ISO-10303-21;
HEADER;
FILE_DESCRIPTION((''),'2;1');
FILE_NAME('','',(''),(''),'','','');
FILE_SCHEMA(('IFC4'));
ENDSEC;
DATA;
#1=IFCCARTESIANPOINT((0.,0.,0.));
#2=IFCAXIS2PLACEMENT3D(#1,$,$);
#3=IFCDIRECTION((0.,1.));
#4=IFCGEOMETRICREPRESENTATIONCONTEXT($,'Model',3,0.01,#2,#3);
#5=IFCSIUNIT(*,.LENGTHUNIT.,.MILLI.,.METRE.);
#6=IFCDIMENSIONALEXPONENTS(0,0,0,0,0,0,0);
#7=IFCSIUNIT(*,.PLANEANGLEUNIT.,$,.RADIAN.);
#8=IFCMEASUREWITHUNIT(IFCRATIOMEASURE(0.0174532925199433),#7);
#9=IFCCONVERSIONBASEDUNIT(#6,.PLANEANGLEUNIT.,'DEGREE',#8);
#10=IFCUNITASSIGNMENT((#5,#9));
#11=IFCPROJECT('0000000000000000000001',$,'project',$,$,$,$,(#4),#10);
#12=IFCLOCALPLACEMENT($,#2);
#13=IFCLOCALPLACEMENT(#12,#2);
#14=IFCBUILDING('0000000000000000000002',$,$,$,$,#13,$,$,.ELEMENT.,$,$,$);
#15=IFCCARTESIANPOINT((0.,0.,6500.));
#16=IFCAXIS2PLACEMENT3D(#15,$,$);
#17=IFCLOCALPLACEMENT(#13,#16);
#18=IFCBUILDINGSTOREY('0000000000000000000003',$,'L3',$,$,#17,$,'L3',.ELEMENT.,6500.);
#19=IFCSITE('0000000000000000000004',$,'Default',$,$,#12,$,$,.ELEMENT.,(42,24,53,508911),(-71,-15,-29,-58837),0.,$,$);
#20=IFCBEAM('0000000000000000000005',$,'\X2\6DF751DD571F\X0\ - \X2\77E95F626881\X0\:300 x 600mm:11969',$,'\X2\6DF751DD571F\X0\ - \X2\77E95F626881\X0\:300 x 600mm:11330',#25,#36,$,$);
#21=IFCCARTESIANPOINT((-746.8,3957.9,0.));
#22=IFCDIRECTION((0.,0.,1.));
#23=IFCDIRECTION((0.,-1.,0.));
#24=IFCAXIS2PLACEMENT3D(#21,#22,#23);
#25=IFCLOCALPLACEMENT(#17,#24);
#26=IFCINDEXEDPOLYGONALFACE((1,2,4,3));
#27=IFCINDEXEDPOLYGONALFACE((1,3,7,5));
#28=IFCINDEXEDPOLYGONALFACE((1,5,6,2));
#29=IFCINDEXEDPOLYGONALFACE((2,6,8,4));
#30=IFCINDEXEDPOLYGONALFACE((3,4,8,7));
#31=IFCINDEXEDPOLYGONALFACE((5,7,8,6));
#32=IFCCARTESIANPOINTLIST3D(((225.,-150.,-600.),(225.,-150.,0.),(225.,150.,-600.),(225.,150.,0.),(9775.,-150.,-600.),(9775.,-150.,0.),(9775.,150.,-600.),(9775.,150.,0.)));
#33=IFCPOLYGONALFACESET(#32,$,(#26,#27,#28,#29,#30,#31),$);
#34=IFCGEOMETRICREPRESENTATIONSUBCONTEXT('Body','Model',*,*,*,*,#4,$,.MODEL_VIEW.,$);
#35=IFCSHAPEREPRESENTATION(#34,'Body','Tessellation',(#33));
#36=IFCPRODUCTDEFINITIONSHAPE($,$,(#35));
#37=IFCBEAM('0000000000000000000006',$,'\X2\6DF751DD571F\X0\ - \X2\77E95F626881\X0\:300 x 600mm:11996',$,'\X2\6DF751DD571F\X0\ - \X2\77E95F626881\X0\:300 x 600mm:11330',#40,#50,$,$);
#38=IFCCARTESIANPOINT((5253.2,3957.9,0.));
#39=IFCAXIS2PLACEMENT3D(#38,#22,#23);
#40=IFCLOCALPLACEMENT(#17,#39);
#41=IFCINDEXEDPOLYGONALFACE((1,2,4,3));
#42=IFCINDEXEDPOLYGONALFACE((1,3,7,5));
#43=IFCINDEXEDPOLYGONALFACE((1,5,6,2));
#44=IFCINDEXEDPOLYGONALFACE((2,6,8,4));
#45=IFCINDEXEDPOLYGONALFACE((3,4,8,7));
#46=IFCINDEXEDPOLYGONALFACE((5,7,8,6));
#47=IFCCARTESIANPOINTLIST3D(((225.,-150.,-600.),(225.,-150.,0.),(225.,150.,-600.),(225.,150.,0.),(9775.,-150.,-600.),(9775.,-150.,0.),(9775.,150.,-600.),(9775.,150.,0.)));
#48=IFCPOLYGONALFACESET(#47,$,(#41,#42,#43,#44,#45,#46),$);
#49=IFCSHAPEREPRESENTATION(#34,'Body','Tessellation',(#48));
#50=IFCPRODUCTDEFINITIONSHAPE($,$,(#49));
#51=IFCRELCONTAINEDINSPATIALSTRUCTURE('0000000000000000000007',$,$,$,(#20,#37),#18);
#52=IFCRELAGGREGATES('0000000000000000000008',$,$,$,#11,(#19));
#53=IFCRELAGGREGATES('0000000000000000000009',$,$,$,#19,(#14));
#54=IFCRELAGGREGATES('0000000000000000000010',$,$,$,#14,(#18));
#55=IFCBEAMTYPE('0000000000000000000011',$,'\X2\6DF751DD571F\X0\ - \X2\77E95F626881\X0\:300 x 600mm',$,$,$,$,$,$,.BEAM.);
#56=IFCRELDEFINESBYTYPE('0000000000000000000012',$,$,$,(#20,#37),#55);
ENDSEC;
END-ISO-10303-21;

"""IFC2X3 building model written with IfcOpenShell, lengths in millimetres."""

from ifc_helpers import new_model, entity, si_unit, converted_unit, direction, frame, frame_2d, origin, origin_2d_with_axis, place, context, subcontext, project, spatial, rectangle, extrude, type_object, element, save


model = new_model("IFC2X3")

# Units and contexts
model_context = context("Model", 3, precision=0.01, world=origin(), true_north=direction((0.0, 1.0)))
body_context = subcontext(model_context, "Body", "Model", "MODEL_VIEW")
ifc_project = project(units=[si_unit("LENGTHUNIT", "METRE", prefix="MILLI"), converted_unit("PLANEANGLEUNIT", "DEGREE", entity("IfcRatioMeasure", 0.0174532925199433), si_unit("PLANEANGLEUNIT", "RADIAN"), dimensions=[0, 0, 0, 0, 0, 0, 0])], contexts=[model_context])

# Site, building, storey
site_placement = place(None, origin())
site = spatial("IfcSite", under=ifc_project, at=site_placement, Name="Default", CompositionType="ELEMENT", RefLatitude=(42, 24, 53, 508911), RefLongitude=(-71, -15, -29, -58837), RefElevation=0.0)
building_placement = place(site_placement, origin())
building = spatial("IfcBuilding", under=site, at=building_placement, CompositionType="ELEMENT")
storey_placement = place(building_placement, frame((0.0, 0.0, 6500.0)))
storey = spatial("IfcBuildingStorey", under=building, at=storey_placement, Name="L3", LongName="L3", CompositionType="ELEMENT", Elevation=6500.0)

# Beams
beam_type_1 = type_object("IfcBeamType", Name="混凝土 - 矩形梁:300 x 600mm", PredefinedType="BEAM")
beam_1_placement = place(storey_placement, frame((-746.8, 3957.9, 0.0), z_axis=(0.0, 0.0, 1.0), x_axis=(0.0, -1.0, 0.0)))
element("IfcBeam", 1, at=beam_1_placement, inside=storey, type_object=beam_type_1, Name="混凝土 - 矩形梁:300 x 600mm:11969", ObjectType="混凝土 - 矩形梁:300 x 600mm:11330", context=body_context, shape_type="SweptSolid", body=[
    extrude(rectangle(XDim=600.0, YDim=300.0, at=frame_2d((0.0, 0.0), x_axis=(1.0, 0.0))), frame((225.0, 0.0, -300.0), z_axis=(1.0, 0.0, 0.0), x_axis=(0.0, 0.0, -1.0)), (0.0, 0.0, 1.0), 9550.0),
])
beam_2_placement = place(storey_placement, frame((5253.2, 3957.9, 0.0), z_axis=(0.0, 0.0, 1.0), x_axis=(0.0, -1.0, 0.0)))
element("IfcBeam", 2, at=beam_2_placement, inside=storey, type_object=beam_type_1, Name="混凝土 - 矩形梁:300 x 600mm:11996", ObjectType="混凝土 - 矩形梁:300 x 600mm:11330", context=body_context, shape_type="SweptSolid", body=[
    extrude(rectangle(XDim=600.0, YDim=300.0, at=origin_2d_with_axis()), frame((225.0, 0.0, -300.0), z_axis=(1.0, 0.0, 0.0), x_axis=(0.0, 0.0, -1.0)), (0.0, 0.0, 1.0), 9550.0),
])

save(model, "model.ifc")
